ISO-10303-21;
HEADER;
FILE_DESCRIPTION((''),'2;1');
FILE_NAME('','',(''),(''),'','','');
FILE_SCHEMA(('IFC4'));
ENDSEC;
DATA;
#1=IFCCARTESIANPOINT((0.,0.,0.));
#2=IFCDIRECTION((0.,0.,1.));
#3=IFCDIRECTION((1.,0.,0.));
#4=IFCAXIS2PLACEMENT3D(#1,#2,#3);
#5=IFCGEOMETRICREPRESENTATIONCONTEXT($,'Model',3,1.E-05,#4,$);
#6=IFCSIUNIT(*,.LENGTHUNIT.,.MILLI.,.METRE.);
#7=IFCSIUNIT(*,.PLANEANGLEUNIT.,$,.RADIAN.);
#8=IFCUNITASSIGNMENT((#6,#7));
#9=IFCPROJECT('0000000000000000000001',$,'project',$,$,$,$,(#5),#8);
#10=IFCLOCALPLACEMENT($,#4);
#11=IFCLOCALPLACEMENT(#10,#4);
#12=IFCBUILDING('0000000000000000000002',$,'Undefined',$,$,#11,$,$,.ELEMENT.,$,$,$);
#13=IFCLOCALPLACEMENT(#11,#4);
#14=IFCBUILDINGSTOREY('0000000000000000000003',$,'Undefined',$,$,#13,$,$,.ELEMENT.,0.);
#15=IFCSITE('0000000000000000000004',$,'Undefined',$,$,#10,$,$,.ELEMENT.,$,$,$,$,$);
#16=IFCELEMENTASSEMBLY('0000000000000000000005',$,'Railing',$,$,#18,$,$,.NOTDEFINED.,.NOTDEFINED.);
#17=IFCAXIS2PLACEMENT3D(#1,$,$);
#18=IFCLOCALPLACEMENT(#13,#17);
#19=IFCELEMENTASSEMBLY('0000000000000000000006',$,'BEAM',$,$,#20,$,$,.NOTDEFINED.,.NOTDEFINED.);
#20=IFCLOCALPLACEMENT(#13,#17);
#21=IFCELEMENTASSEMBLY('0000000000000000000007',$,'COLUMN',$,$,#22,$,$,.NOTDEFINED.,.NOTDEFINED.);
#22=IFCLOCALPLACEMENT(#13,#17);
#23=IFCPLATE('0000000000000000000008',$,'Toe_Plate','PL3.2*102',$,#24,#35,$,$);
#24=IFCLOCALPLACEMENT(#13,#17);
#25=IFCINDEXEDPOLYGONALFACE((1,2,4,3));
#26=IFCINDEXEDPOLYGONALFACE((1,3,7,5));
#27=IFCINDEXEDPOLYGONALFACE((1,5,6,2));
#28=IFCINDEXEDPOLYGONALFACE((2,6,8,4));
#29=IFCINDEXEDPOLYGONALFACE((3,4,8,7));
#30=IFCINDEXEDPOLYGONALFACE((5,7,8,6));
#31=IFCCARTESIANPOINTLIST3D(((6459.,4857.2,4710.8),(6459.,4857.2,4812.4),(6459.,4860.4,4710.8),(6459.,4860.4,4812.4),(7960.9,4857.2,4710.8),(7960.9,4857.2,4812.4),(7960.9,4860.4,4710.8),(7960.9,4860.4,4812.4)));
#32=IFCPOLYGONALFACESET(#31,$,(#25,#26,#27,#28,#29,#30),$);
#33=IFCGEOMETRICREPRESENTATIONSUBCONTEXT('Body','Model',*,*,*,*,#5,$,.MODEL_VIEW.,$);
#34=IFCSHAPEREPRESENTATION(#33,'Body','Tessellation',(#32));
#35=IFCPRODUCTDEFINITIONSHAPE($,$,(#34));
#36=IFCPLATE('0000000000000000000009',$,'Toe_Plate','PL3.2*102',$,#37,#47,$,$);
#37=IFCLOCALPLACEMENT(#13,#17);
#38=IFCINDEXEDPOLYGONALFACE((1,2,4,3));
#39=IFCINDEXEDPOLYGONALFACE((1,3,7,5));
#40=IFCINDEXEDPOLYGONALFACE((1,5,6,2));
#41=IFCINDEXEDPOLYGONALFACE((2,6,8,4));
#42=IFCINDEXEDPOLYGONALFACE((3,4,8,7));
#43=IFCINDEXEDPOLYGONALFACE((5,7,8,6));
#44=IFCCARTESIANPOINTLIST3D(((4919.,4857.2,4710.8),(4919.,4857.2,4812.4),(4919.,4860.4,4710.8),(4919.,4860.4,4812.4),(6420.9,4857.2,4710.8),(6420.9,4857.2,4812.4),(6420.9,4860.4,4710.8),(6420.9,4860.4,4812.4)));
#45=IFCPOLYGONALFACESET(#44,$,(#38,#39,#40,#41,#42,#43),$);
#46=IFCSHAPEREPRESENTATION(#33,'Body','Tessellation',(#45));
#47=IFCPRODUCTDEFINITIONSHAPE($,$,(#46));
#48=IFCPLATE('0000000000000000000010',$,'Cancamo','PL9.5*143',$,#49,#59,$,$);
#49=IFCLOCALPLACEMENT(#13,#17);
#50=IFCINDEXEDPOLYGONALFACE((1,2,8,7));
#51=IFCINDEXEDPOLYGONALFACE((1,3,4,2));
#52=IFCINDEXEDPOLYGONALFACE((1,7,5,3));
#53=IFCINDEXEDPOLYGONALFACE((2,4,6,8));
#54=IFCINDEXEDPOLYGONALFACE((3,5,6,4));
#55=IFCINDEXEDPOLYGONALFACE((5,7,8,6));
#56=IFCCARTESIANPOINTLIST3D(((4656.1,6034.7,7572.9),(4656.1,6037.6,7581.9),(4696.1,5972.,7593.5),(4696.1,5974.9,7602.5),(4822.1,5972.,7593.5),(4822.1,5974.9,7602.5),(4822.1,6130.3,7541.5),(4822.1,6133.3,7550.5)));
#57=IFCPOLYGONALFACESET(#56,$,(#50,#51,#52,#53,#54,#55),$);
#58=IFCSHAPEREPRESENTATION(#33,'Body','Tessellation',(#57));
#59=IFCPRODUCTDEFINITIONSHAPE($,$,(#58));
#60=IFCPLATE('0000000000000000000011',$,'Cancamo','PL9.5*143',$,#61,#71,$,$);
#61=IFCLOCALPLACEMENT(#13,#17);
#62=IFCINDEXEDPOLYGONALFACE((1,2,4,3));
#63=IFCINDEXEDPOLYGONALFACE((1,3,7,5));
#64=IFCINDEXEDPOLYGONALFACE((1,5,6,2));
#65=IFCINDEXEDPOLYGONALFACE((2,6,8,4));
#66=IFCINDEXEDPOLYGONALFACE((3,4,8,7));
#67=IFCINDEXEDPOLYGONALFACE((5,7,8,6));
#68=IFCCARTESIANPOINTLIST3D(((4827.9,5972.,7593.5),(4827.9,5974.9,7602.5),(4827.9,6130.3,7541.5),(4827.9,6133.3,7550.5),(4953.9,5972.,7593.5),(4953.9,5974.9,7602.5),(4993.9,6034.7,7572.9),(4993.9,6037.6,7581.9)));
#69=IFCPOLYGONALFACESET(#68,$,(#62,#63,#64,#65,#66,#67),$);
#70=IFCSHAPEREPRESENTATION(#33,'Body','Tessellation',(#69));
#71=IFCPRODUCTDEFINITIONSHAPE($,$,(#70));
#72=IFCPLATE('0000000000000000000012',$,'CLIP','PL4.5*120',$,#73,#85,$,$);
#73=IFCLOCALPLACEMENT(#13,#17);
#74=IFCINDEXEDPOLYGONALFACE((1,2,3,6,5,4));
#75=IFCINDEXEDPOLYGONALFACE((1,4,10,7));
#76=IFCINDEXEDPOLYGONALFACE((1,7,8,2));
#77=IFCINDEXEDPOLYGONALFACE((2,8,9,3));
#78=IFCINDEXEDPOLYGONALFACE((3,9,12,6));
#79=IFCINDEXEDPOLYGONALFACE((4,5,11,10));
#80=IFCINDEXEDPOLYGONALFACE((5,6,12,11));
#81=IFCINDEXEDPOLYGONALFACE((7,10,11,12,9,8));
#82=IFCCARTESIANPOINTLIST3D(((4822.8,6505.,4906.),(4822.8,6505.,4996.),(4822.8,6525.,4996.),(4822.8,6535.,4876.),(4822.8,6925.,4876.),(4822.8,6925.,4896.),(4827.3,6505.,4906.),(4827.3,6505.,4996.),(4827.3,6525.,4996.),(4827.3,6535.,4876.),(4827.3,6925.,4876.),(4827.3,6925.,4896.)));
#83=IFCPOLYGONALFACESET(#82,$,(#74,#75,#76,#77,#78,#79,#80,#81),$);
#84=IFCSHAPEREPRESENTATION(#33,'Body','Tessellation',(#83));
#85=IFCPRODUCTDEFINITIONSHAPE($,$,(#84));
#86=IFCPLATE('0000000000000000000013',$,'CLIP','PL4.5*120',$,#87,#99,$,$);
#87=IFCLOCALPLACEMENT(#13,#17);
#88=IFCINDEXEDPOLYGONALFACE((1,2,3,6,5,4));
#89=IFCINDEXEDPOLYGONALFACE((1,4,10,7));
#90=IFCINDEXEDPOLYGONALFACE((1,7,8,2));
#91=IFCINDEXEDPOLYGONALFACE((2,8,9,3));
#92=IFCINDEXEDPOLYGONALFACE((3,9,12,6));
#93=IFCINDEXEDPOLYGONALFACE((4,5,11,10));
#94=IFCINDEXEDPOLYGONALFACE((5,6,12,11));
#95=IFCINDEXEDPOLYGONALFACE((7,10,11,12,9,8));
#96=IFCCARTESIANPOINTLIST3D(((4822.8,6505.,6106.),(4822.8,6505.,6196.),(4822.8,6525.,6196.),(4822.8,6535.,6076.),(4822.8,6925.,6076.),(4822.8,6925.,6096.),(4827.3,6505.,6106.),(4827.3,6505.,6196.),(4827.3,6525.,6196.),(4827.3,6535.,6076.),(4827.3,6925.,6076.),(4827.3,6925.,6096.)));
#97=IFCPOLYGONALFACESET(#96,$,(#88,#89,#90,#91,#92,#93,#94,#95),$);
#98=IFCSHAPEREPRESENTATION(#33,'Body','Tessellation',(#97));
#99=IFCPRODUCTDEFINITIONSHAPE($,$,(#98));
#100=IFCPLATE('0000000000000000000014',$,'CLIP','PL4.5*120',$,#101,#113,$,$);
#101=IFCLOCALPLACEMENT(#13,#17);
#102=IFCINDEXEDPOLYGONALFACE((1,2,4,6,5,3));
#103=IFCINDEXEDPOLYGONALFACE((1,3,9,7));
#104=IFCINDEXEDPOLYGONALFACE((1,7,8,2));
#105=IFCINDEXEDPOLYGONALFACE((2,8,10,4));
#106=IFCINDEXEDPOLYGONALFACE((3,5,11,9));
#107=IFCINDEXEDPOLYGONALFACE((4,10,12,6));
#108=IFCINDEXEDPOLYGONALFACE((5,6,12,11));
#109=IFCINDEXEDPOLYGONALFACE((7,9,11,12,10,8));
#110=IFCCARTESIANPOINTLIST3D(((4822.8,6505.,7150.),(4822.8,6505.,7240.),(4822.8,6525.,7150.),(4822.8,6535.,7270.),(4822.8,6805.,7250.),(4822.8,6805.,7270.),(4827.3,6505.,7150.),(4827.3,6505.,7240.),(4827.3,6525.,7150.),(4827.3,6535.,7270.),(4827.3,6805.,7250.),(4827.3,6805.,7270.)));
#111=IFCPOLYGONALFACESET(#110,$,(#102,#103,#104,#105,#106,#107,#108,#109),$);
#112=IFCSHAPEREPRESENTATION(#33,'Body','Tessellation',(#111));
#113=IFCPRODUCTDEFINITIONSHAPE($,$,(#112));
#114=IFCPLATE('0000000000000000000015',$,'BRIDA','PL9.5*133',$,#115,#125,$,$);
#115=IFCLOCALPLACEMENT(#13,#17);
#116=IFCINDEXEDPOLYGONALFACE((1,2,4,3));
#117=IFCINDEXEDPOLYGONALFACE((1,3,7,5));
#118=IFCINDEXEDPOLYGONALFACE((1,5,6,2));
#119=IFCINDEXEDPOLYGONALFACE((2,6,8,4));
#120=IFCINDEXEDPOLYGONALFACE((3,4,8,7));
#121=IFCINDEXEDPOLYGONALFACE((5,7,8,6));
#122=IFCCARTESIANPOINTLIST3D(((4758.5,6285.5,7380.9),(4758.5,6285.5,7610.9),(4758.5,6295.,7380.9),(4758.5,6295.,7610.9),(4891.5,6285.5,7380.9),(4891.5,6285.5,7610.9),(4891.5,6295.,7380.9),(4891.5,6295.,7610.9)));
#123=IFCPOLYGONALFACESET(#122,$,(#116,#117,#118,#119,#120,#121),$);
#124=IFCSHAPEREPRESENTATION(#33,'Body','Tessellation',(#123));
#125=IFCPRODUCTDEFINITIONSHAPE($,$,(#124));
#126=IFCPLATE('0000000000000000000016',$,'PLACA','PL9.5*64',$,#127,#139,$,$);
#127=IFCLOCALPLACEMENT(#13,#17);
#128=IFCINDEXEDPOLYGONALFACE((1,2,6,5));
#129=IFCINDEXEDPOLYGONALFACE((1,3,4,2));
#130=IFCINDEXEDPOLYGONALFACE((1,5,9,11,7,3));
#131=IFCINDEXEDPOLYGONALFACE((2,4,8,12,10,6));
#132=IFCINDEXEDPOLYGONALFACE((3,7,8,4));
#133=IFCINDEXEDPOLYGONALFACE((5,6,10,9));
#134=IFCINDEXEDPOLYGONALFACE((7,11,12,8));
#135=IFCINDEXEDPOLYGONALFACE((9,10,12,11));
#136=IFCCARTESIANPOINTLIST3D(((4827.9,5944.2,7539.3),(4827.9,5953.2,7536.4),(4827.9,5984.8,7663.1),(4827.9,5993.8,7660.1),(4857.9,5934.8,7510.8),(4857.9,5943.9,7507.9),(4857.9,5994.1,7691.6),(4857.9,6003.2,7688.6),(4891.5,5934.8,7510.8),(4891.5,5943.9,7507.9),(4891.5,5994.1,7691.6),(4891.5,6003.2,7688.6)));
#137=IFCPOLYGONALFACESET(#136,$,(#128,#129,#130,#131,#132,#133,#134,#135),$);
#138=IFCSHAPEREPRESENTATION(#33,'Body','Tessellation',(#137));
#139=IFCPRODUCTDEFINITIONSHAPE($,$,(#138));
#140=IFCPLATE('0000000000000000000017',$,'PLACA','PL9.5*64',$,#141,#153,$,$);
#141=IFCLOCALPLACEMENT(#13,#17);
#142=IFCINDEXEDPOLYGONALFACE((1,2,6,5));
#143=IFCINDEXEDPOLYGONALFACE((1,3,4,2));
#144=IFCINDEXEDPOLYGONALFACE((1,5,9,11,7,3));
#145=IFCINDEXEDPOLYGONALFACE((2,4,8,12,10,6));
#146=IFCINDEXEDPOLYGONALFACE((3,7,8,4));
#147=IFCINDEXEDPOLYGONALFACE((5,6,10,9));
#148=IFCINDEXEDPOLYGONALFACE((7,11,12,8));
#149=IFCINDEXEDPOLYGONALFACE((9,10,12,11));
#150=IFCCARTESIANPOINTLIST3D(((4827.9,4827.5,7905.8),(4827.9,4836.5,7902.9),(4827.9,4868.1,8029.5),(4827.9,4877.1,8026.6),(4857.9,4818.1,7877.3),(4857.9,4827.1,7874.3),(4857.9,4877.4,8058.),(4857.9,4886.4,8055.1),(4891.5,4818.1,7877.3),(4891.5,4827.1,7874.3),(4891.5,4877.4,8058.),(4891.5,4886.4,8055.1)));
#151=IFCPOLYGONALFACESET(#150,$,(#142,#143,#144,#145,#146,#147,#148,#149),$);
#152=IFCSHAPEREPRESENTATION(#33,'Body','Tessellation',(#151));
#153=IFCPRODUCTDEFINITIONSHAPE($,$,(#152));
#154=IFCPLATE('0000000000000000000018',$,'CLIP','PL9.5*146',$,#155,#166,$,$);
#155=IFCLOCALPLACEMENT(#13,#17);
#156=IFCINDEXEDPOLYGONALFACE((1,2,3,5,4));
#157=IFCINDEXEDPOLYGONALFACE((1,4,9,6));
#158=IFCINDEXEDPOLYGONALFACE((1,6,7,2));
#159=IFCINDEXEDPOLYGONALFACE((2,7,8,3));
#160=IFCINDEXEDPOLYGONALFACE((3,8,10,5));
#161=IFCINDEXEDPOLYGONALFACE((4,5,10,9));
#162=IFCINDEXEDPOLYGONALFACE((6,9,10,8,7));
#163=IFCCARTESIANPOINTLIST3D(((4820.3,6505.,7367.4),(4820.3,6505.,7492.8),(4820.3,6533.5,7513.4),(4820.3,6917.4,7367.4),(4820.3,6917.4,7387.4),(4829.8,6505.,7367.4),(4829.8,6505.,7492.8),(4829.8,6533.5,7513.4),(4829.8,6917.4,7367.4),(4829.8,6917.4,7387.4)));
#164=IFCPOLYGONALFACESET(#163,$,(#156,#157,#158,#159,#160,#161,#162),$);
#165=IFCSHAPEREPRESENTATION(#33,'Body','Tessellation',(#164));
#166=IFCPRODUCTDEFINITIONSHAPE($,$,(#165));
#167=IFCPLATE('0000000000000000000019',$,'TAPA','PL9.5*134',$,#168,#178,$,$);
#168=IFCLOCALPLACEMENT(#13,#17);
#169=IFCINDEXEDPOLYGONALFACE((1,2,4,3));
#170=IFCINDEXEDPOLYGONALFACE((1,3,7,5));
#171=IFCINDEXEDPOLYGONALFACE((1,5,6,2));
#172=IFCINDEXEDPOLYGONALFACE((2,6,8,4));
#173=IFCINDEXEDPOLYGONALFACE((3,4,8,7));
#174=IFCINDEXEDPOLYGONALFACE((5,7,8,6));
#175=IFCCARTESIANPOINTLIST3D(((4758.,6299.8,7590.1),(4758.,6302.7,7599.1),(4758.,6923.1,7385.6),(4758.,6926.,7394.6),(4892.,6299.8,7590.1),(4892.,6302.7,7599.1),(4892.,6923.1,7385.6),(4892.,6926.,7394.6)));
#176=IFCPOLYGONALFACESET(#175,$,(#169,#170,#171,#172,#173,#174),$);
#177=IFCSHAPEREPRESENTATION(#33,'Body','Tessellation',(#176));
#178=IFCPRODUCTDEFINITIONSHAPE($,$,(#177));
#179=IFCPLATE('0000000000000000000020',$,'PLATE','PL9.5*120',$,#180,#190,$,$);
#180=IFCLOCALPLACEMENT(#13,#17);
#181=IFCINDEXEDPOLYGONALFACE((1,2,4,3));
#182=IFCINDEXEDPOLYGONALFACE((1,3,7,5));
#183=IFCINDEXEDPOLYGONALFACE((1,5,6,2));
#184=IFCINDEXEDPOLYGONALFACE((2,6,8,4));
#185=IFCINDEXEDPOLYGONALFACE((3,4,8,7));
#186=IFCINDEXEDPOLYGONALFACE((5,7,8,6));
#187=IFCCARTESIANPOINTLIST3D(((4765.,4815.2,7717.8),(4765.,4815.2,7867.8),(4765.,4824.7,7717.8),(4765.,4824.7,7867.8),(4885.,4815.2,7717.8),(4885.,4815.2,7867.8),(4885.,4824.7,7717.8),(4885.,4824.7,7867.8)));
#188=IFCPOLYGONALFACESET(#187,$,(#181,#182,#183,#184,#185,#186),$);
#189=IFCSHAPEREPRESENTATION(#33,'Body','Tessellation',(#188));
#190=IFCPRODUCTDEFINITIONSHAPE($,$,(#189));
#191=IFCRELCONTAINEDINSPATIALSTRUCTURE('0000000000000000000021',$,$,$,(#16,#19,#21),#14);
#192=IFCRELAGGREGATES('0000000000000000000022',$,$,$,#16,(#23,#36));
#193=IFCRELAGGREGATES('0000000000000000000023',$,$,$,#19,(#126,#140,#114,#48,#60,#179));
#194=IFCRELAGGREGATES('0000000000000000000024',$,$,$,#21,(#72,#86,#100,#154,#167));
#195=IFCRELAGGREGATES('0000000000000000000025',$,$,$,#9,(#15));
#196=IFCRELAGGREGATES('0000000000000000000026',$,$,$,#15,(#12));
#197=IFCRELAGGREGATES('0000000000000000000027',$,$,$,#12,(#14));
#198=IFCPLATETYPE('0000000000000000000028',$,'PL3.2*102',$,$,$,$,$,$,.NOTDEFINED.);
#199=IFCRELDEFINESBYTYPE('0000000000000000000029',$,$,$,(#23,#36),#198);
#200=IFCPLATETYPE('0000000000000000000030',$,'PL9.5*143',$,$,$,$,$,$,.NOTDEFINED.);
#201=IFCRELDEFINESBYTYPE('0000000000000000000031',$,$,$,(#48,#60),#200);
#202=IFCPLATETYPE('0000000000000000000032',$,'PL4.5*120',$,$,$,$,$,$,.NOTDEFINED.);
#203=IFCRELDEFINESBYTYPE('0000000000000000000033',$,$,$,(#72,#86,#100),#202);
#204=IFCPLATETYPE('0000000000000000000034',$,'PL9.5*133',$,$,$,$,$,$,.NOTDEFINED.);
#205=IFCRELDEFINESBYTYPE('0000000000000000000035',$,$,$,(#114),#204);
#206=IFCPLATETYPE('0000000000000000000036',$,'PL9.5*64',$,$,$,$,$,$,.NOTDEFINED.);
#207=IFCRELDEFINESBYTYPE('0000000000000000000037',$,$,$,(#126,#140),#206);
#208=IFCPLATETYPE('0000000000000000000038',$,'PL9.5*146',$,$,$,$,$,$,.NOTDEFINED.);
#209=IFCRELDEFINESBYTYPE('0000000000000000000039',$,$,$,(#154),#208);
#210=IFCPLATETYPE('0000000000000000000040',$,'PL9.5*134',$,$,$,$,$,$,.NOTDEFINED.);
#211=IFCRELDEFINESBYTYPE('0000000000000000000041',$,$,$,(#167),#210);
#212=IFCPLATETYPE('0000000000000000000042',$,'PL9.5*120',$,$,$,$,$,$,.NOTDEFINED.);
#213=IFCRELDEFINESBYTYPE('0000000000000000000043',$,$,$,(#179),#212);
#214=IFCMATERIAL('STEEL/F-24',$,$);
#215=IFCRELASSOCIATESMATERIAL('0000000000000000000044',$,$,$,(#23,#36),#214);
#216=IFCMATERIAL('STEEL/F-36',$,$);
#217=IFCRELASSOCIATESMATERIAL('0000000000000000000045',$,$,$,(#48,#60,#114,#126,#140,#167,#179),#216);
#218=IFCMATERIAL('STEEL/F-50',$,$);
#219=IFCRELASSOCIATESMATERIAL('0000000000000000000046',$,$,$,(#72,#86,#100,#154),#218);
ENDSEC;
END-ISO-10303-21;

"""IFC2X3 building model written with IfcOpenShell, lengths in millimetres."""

from ifc_helpers import new_model, si_unit, frame, origin_with_axes, place, context, subcontext, project, spatial, polyline, outline, extrude, material, type_object, element, aggregate, save


model = new_model("IFC2X3")

# Units and contexts
model_context = context("Model", 3, precision=1e-05, world=origin_with_axes())
body_context = subcontext(model_context, "Body", "Model", "MODEL_VIEW")
ifc_project = project(units=[si_unit("LENGTHUNIT", "METRE", prefix="MILLI"), si_unit("PLANEANGLEUNIT", "RADIAN")], contexts=[model_context])

# Site, building, storey
site_placement = place(None, origin_with_axes())
site = spatial("IfcSite", under=ifc_project, at=site_placement, Name="Undefined", CompositionType="ELEMENT")
building_placement = place(site_placement, origin_with_axes())
building = spatial("IfcBuilding", under=site, at=building_placement, Name="Undefined", CompositionType="ELEMENT")
storey_placement = place(building_placement, origin_with_axes())
storey = spatial("IfcBuildingStorey", under=building, at=storey_placement, Name="Undefined", CompositionType="ELEMENT", Elevation=0.0)

# Element assembly
ifc_material_1 = material(Name="STEEL/F-24")
assembly_1_placement = place(storey_placement, origin_with_axes())
assembly_1 = element("IfcElementAssembly", 1, at=assembly_1_placement, inside=storey, Name="Railing", AssemblyPlace="NOTDEFINED", PredefinedType="NOTDEFINED")

# Element assembly
assembly_2_placement = place(storey_placement, origin_with_axes())
assembly_2 = element("IfcElementAssembly", 2, at=assembly_2_placement, inside=storey, Name="BEAM", AssemblyPlace="NOTDEFINED", PredefinedType="NOTDEFINED")
ifc_material_2 = material(Name="STEEL/F-36")

# Element assembly
assembly_3_placement = place(storey_placement, origin_with_axes())
assembly_3 = element("IfcElementAssembly", 3, at=assembly_3_placement, inside=storey, Name="COLUMN", AssemblyPlace="NOTDEFINED", PredefinedType="NOTDEFINED")

# Plates
plate_type_1 = type_object("IfcPlateType", Name="PL3.2*102", PredefinedType="NOTDEFINED")
plate_1_placement = place(assembly_1_placement, frame((6459.0, 4858.8, 4710.8), z_axis=(0.0, -1.0, 0.0), x_axis=(1.0, 0.0, 0.0)))
plate_1 = element("IfcPlate", 4, at=plate_1_placement, type_object=plate_type_1, material=ifc_material_1, Name="Toe_Plate", Description="PL3.2*102", context=body_context, shape_type="SweptSolid", body=[
    extrude(outline(polyline([(0.0, 0.0), (1501.9, 0.0), (1501.9, 101.6), (0.0, 101.6), (0.0, 0.0)])), frame((0.0, 0.0, -1.6), z_axis=(0.0, 0.0, 1.0), x_axis=(1.0, 0.0, 0.0)), (0.0, 0.0, 1.0), 3.2),
])
plate_2_placement = place(assembly_1_placement, frame((4919.0, 4858.8, 4710.8), z_axis=(0.0, -1.0, 0.0), x_axis=(1.0, 0.0, 0.0)))
plate_2 = element("IfcPlate", 5, at=plate_2_placement, type_object=plate_type_1, material=ifc_material_1, Name="Toe_Plate", Description="PL3.2*102", context=body_context, shape_type="SweptSolid", body=[
    extrude(outline(polyline([(0.0, 0.0), (1501.9, 0.0), (1501.9, 101.6), (0.0, 101.6), (0.0, 0.0)])), frame((0.0, 0.0, -1.6), z_axis=(0.0, 0.0, 1.0), x_axis=(1.0, 0.0, 0.0)), (0.0, 0.0, 1.0), 3.2),
])
aggregate(assembly_1, [plate_1, plate_2])
plate_type_2 = type_object("IfcPlateType", Name="PL9.5*143", PredefinedType="NOTDEFINED")
plate_3_placement = place(assembly_2_placement, frame((4822.1, 6131.8, 7546.0), z_axis=(0.00002, -0.311803, -0.950147), x_axis=(0.0, -0.950147, 0.311803)))
plate_3 = element("IfcPlate", 6, at=plate_3_placement, type_object=plate_type_2, material=ifc_material_2, Name="Cancamo", Description="PL9.5*143", context=body_context, shape_type="SweptSolid", body=[
    extrude(outline(polyline([(0.0, 0.0), (166.7, 0.0), (166.7, 126.0), (100.7, 166.0), (0.0, 0.0)])), frame((0.0, 0.0, -4.8), z_axis=(0.0, 0.0, 1.0), x_axis=(1.0, 0.0, 0.0)), (0.0, 0.0, 1.0), 9.5),
])
plate_4_placement = place(assembly_2_placement, frame((4827.9, 6131.8, 7546.0), z_axis=(0.00002, 0.311803, 0.950147), x_axis=(0.0, -0.950147, 0.311803)))
plate_4 = element("IfcPlate", 7, at=plate_4_placement, type_object=plate_type_2, material=ifc_material_2, Name="Cancamo", Description="PL9.5*143", context=body_context, shape_type="SweptSolid", body=[
    extrude(outline(polyline([(0.0, 0.0), (166.7, 0.0), (166.7, 126.0), (100.7, 166.0), (0.0, 0.0)])), frame((0.0, 0.0, -4.8), z_axis=(0.0, 0.0, 1.0), x_axis=(1.0, 0.0, 0.0)), (0.0, 0.0, 1.0), 9.5),
])
ifc_material_3 = material(Name="STEEL/F-50")
plate_type_3 = type_object("IfcPlateType", Name="PL4.5*120", PredefinedType="NOTDEFINED")
plate_5_placement = place(assembly_3_placement, frame((4825.0, 6925.0, 4876.0), z_axis=(1.0, 0.0, 0.0), x_axis=(0.0, 0.0, 1.0)))
plate_5 = element("IfcPlate", 8, at=plate_5_placement, type_object=plate_type_3, material=ifc_material_3, Name="CLIP", Description="PL4.5*120", context=body_context, shape_type="SweptSolid", body=[
    extrude(outline(polyline([(0.0, 0.0), (20.0, 0.0), (120.0, 400.0), (120.0, 420.0), (30.0, 420.0), (0.0, 390.0), (0.0, 0.0)])), frame((0.0, 0.0, -2.2), z_axis=(0.0, 0.0, 1.0), x_axis=(1.0, 0.0, 0.0)), (0.0, 0.0, 1.0), 4.5),
])
plate_6_placement = place(assembly_3_placement, frame((4825.0, 6925.0, 6076.0), z_axis=(1.0, 0.0, 0.0), x_axis=(0.0, 0.0, 1.0)))
plate_6 = element("IfcPlate", 9, at=plate_6_placement, type_object=plate_type_3, material=ifc_material_3, Name="CLIP", Description="PL4.5*120", context=body_context, shape_type="SweptSolid", body=[
    extrude(outline(polyline([(0.0, 0.0), (20.0, 0.0), (120.0, 400.0), (120.0, 420.0), (30.0, 420.0), (0.0, 390.0), (0.0, 0.0)])), frame((0.0, 0.0, -2.2), z_axis=(0.0, 0.0, 1.0), x_axis=(1.0, 0.0, 0.0)), (0.0, 0.0, 1.0), 4.5),
])
plate_7_placement = place(assembly_3_placement, frame((4825.0, 6805.0, 7270.0), z_axis=(-1.0, 0.0, 0.0), x_axis=(0.0, 0.0, -1.0)))
plate_7 = element("IfcPlate", 10, at=plate_7_placement, type_object=plate_type_3, material=ifc_material_3, Name="CLIP", Description="PL4.5*120", context=body_context, shape_type="SweptSolid", body=[
    extrude(outline(polyline([(0.0, 0.0), (20.0, 0.0), (120.0, 280.0), (120.0, 300.0), (30.0, 300.0), (0.0, 270.0), (0.0, 0.0)])), frame((0.0, 0.0, -2.2), z_axis=(0.0, 0.0, 1.0), x_axis=(1.0, 0.0, 0.0)), (0.0, 0.0, 1.0), 4.5),
])
plate_type_4 = type_object("IfcPlateType", Name="PL9.5*133", PredefinedType="NOTDEFINED")
plate_8_placement = place(assembly_2_placement, frame((4825.0, 6290.3, 7610.9), z_axis=(0.0, -1.0, 0.0), x_axis=(0.0, 0.0, -1.0)))
plate_8 = element("IfcPlate", 11, at=plate_8_placement, type_object=plate_type_4, material=ifc_material_2, Name="BRIDA", Description="PL9.5*133", context=body_context, shape_type="SweptSolid", body=[
    extrude(outline(polyline([(0.0, -66.5), (0.0, 66.5), (230.0, 66.5), (230.0, -66.5), (0.0, -66.5)])), frame((0.0, 0.0, -4.8), z_axis=(0.0, 0.0, 1.0), x_axis=(1.0, 0.0, 0.0)), (0.0, 0.0, 1.0), 9.5),
])
plate_type_5 = type_object("IfcPlateType", Name="PL9.5*64", PredefinedType="NOTDEFINED")
plate_9_placement = place(assembly_2_placement, frame((4827.9, 5998.7, 7690.1), z_axis=(0.0, 0.950147, -0.311803), x_axis=(1.0, 0.0, 0.0)))
plate_9 = element("IfcPlate", 12, at=plate_9_placement, type_object=plate_type_5, material=ifc_material_2, Name="PLACA", Description="PL9.5*64", context=body_context, shape_type="SweptSolid", body=[
    extrude(outline(polyline([(0.0, 30.0), (30.0, 0.0), (63.6, 0.0), (63.6, 190.2), (30.0, 190.2), (0.0, 160.2), (0.0, 30.0)])), frame((0.0, 0.0, -4.8), z_axis=(0.0, 0.0, 1.0), x_axis=(1.0, 0.0, 0.0)), (0.0, 0.0, 1.0), 9.5),
])
plate_10_placement = place(assembly_2_placement, frame((4827.9, 4881.9, 8056.5), z_axis=(0.0, 0.950147, -0.311803), x_axis=(1.0, 0.0, 0.0)))
plate_10 = element("IfcPlate", 13, at=plate_10_placement, type_object=plate_type_5, material=ifc_material_2, Name="PLACA", Description="PL9.5*64", context=body_context, shape_type="SweptSolid", body=[
    extrude(outline(polyline([(0.0, 30.0), (30.0, 0.0), (63.6, 0.0), (63.6, 190.2), (30.0, 190.2), (0.0, 160.2), (0.0, 30.0)])), frame((0.0, 0.0, -4.8), z_axis=(0.0, 0.0, 1.0), x_axis=(1.0, 0.0, 0.0)), (0.0, 0.0, 1.0), 9.5),
])
plate_type_6 = type_object("IfcPlateType", Name="PL9.5*146", PredefinedType="NOTDEFINED")
plate_11_placement = place(assembly_3_placement, frame((4825.0, 6917.4, 7387.4), z_axis=(-1.0, 0.0, 0.0), x_axis=(0.0, 0.0, -1.0)))
plate_11 = element("IfcPlate", 14, at=plate_11_placement, type_object=plate_type_6, material=ifc_material_3, Name="CLIP", Description="PL9.5*146", context=body_context, shape_type="SweptSolid", body=[
    extrude(outline(polyline([(0.0, 0.0), (20.0, 0.0), (20.0, 412.5), (-105.4, 412.5), (-126.0, 383.9), (0.0, 0.0)])), frame((0.0, 0.0, -4.8), z_axis=(0.0, 0.0, 1.0), x_axis=(1.0, 0.0, 0.0)), (0.0, 0.0, 1.0), 9.5),
])
plate_type_7 = type_object("IfcPlateType", Name="PL9.5*134", PredefinedType="NOTDEFINED")
plate_12_placement = place(assembly_3_placement, frame((4825.0, 6301.2, 7594.6), z_axis=(0.0, -0.311803, -0.950147), x_axis=(0.0, 0.950147, -0.311803)))
plate_12 = element("IfcPlate", 15, at=plate_12_placement, type_object=plate_type_7, material=ifc_material_2, Name="TAPA", Description="PL9.5*134", context=body_context, shape_type="SweptSolid", body=[
    extrude(outline(polyline([(0.0, -67.0), (0.0, 67.0), (656.0, 67.0), (656.0, -67.0), (0.0, -67.0)])), frame((0.0, 0.0, -4.8), z_axis=(0.0, 0.0, 1.0), x_axis=(1.0, 0.0, 0.0)), (0.0, 0.0, 1.0), 9.5),
])
plate_type_8 = type_object("IfcPlateType", Name="PL9.5*120", PredefinedType="NOTDEFINED")
plate_13_placement = place(assembly_2_placement, frame((4885.0, 4820.0, 7867.8), z_axis=(0.0, -1.0, 0.0), x_axis=(-1.0, 0.0, 0.0)))
plate_13 = element("IfcPlate", 16, at=plate_13_placement, type_object=plate_type_8, material=ifc_material_2, Name="PLATE", Description="PL9.5*120", context=body_context, shape_type="SweptSolid", body=[
    extrude(outline(polyline([(0.0, 0.0), (120.0, 0.0), (120.0, 150.0), (0.0, 150.0), (0.0, 0.0)])), frame((0.0, 0.0, -4.8), z_axis=(0.0, 0.0, 1.0), x_axis=(1.0, 0.0, 0.0)), (0.0, 0.0, 1.0), 9.5),
])
aggregate(assembly_2, [plate_9, plate_10, plate_8, plate_3, plate_4, plate_13])

aggregate(assembly_3, [plate_5, plate_6, plate_7, plate_11, plate_12])

save(model, "model.ifc")
